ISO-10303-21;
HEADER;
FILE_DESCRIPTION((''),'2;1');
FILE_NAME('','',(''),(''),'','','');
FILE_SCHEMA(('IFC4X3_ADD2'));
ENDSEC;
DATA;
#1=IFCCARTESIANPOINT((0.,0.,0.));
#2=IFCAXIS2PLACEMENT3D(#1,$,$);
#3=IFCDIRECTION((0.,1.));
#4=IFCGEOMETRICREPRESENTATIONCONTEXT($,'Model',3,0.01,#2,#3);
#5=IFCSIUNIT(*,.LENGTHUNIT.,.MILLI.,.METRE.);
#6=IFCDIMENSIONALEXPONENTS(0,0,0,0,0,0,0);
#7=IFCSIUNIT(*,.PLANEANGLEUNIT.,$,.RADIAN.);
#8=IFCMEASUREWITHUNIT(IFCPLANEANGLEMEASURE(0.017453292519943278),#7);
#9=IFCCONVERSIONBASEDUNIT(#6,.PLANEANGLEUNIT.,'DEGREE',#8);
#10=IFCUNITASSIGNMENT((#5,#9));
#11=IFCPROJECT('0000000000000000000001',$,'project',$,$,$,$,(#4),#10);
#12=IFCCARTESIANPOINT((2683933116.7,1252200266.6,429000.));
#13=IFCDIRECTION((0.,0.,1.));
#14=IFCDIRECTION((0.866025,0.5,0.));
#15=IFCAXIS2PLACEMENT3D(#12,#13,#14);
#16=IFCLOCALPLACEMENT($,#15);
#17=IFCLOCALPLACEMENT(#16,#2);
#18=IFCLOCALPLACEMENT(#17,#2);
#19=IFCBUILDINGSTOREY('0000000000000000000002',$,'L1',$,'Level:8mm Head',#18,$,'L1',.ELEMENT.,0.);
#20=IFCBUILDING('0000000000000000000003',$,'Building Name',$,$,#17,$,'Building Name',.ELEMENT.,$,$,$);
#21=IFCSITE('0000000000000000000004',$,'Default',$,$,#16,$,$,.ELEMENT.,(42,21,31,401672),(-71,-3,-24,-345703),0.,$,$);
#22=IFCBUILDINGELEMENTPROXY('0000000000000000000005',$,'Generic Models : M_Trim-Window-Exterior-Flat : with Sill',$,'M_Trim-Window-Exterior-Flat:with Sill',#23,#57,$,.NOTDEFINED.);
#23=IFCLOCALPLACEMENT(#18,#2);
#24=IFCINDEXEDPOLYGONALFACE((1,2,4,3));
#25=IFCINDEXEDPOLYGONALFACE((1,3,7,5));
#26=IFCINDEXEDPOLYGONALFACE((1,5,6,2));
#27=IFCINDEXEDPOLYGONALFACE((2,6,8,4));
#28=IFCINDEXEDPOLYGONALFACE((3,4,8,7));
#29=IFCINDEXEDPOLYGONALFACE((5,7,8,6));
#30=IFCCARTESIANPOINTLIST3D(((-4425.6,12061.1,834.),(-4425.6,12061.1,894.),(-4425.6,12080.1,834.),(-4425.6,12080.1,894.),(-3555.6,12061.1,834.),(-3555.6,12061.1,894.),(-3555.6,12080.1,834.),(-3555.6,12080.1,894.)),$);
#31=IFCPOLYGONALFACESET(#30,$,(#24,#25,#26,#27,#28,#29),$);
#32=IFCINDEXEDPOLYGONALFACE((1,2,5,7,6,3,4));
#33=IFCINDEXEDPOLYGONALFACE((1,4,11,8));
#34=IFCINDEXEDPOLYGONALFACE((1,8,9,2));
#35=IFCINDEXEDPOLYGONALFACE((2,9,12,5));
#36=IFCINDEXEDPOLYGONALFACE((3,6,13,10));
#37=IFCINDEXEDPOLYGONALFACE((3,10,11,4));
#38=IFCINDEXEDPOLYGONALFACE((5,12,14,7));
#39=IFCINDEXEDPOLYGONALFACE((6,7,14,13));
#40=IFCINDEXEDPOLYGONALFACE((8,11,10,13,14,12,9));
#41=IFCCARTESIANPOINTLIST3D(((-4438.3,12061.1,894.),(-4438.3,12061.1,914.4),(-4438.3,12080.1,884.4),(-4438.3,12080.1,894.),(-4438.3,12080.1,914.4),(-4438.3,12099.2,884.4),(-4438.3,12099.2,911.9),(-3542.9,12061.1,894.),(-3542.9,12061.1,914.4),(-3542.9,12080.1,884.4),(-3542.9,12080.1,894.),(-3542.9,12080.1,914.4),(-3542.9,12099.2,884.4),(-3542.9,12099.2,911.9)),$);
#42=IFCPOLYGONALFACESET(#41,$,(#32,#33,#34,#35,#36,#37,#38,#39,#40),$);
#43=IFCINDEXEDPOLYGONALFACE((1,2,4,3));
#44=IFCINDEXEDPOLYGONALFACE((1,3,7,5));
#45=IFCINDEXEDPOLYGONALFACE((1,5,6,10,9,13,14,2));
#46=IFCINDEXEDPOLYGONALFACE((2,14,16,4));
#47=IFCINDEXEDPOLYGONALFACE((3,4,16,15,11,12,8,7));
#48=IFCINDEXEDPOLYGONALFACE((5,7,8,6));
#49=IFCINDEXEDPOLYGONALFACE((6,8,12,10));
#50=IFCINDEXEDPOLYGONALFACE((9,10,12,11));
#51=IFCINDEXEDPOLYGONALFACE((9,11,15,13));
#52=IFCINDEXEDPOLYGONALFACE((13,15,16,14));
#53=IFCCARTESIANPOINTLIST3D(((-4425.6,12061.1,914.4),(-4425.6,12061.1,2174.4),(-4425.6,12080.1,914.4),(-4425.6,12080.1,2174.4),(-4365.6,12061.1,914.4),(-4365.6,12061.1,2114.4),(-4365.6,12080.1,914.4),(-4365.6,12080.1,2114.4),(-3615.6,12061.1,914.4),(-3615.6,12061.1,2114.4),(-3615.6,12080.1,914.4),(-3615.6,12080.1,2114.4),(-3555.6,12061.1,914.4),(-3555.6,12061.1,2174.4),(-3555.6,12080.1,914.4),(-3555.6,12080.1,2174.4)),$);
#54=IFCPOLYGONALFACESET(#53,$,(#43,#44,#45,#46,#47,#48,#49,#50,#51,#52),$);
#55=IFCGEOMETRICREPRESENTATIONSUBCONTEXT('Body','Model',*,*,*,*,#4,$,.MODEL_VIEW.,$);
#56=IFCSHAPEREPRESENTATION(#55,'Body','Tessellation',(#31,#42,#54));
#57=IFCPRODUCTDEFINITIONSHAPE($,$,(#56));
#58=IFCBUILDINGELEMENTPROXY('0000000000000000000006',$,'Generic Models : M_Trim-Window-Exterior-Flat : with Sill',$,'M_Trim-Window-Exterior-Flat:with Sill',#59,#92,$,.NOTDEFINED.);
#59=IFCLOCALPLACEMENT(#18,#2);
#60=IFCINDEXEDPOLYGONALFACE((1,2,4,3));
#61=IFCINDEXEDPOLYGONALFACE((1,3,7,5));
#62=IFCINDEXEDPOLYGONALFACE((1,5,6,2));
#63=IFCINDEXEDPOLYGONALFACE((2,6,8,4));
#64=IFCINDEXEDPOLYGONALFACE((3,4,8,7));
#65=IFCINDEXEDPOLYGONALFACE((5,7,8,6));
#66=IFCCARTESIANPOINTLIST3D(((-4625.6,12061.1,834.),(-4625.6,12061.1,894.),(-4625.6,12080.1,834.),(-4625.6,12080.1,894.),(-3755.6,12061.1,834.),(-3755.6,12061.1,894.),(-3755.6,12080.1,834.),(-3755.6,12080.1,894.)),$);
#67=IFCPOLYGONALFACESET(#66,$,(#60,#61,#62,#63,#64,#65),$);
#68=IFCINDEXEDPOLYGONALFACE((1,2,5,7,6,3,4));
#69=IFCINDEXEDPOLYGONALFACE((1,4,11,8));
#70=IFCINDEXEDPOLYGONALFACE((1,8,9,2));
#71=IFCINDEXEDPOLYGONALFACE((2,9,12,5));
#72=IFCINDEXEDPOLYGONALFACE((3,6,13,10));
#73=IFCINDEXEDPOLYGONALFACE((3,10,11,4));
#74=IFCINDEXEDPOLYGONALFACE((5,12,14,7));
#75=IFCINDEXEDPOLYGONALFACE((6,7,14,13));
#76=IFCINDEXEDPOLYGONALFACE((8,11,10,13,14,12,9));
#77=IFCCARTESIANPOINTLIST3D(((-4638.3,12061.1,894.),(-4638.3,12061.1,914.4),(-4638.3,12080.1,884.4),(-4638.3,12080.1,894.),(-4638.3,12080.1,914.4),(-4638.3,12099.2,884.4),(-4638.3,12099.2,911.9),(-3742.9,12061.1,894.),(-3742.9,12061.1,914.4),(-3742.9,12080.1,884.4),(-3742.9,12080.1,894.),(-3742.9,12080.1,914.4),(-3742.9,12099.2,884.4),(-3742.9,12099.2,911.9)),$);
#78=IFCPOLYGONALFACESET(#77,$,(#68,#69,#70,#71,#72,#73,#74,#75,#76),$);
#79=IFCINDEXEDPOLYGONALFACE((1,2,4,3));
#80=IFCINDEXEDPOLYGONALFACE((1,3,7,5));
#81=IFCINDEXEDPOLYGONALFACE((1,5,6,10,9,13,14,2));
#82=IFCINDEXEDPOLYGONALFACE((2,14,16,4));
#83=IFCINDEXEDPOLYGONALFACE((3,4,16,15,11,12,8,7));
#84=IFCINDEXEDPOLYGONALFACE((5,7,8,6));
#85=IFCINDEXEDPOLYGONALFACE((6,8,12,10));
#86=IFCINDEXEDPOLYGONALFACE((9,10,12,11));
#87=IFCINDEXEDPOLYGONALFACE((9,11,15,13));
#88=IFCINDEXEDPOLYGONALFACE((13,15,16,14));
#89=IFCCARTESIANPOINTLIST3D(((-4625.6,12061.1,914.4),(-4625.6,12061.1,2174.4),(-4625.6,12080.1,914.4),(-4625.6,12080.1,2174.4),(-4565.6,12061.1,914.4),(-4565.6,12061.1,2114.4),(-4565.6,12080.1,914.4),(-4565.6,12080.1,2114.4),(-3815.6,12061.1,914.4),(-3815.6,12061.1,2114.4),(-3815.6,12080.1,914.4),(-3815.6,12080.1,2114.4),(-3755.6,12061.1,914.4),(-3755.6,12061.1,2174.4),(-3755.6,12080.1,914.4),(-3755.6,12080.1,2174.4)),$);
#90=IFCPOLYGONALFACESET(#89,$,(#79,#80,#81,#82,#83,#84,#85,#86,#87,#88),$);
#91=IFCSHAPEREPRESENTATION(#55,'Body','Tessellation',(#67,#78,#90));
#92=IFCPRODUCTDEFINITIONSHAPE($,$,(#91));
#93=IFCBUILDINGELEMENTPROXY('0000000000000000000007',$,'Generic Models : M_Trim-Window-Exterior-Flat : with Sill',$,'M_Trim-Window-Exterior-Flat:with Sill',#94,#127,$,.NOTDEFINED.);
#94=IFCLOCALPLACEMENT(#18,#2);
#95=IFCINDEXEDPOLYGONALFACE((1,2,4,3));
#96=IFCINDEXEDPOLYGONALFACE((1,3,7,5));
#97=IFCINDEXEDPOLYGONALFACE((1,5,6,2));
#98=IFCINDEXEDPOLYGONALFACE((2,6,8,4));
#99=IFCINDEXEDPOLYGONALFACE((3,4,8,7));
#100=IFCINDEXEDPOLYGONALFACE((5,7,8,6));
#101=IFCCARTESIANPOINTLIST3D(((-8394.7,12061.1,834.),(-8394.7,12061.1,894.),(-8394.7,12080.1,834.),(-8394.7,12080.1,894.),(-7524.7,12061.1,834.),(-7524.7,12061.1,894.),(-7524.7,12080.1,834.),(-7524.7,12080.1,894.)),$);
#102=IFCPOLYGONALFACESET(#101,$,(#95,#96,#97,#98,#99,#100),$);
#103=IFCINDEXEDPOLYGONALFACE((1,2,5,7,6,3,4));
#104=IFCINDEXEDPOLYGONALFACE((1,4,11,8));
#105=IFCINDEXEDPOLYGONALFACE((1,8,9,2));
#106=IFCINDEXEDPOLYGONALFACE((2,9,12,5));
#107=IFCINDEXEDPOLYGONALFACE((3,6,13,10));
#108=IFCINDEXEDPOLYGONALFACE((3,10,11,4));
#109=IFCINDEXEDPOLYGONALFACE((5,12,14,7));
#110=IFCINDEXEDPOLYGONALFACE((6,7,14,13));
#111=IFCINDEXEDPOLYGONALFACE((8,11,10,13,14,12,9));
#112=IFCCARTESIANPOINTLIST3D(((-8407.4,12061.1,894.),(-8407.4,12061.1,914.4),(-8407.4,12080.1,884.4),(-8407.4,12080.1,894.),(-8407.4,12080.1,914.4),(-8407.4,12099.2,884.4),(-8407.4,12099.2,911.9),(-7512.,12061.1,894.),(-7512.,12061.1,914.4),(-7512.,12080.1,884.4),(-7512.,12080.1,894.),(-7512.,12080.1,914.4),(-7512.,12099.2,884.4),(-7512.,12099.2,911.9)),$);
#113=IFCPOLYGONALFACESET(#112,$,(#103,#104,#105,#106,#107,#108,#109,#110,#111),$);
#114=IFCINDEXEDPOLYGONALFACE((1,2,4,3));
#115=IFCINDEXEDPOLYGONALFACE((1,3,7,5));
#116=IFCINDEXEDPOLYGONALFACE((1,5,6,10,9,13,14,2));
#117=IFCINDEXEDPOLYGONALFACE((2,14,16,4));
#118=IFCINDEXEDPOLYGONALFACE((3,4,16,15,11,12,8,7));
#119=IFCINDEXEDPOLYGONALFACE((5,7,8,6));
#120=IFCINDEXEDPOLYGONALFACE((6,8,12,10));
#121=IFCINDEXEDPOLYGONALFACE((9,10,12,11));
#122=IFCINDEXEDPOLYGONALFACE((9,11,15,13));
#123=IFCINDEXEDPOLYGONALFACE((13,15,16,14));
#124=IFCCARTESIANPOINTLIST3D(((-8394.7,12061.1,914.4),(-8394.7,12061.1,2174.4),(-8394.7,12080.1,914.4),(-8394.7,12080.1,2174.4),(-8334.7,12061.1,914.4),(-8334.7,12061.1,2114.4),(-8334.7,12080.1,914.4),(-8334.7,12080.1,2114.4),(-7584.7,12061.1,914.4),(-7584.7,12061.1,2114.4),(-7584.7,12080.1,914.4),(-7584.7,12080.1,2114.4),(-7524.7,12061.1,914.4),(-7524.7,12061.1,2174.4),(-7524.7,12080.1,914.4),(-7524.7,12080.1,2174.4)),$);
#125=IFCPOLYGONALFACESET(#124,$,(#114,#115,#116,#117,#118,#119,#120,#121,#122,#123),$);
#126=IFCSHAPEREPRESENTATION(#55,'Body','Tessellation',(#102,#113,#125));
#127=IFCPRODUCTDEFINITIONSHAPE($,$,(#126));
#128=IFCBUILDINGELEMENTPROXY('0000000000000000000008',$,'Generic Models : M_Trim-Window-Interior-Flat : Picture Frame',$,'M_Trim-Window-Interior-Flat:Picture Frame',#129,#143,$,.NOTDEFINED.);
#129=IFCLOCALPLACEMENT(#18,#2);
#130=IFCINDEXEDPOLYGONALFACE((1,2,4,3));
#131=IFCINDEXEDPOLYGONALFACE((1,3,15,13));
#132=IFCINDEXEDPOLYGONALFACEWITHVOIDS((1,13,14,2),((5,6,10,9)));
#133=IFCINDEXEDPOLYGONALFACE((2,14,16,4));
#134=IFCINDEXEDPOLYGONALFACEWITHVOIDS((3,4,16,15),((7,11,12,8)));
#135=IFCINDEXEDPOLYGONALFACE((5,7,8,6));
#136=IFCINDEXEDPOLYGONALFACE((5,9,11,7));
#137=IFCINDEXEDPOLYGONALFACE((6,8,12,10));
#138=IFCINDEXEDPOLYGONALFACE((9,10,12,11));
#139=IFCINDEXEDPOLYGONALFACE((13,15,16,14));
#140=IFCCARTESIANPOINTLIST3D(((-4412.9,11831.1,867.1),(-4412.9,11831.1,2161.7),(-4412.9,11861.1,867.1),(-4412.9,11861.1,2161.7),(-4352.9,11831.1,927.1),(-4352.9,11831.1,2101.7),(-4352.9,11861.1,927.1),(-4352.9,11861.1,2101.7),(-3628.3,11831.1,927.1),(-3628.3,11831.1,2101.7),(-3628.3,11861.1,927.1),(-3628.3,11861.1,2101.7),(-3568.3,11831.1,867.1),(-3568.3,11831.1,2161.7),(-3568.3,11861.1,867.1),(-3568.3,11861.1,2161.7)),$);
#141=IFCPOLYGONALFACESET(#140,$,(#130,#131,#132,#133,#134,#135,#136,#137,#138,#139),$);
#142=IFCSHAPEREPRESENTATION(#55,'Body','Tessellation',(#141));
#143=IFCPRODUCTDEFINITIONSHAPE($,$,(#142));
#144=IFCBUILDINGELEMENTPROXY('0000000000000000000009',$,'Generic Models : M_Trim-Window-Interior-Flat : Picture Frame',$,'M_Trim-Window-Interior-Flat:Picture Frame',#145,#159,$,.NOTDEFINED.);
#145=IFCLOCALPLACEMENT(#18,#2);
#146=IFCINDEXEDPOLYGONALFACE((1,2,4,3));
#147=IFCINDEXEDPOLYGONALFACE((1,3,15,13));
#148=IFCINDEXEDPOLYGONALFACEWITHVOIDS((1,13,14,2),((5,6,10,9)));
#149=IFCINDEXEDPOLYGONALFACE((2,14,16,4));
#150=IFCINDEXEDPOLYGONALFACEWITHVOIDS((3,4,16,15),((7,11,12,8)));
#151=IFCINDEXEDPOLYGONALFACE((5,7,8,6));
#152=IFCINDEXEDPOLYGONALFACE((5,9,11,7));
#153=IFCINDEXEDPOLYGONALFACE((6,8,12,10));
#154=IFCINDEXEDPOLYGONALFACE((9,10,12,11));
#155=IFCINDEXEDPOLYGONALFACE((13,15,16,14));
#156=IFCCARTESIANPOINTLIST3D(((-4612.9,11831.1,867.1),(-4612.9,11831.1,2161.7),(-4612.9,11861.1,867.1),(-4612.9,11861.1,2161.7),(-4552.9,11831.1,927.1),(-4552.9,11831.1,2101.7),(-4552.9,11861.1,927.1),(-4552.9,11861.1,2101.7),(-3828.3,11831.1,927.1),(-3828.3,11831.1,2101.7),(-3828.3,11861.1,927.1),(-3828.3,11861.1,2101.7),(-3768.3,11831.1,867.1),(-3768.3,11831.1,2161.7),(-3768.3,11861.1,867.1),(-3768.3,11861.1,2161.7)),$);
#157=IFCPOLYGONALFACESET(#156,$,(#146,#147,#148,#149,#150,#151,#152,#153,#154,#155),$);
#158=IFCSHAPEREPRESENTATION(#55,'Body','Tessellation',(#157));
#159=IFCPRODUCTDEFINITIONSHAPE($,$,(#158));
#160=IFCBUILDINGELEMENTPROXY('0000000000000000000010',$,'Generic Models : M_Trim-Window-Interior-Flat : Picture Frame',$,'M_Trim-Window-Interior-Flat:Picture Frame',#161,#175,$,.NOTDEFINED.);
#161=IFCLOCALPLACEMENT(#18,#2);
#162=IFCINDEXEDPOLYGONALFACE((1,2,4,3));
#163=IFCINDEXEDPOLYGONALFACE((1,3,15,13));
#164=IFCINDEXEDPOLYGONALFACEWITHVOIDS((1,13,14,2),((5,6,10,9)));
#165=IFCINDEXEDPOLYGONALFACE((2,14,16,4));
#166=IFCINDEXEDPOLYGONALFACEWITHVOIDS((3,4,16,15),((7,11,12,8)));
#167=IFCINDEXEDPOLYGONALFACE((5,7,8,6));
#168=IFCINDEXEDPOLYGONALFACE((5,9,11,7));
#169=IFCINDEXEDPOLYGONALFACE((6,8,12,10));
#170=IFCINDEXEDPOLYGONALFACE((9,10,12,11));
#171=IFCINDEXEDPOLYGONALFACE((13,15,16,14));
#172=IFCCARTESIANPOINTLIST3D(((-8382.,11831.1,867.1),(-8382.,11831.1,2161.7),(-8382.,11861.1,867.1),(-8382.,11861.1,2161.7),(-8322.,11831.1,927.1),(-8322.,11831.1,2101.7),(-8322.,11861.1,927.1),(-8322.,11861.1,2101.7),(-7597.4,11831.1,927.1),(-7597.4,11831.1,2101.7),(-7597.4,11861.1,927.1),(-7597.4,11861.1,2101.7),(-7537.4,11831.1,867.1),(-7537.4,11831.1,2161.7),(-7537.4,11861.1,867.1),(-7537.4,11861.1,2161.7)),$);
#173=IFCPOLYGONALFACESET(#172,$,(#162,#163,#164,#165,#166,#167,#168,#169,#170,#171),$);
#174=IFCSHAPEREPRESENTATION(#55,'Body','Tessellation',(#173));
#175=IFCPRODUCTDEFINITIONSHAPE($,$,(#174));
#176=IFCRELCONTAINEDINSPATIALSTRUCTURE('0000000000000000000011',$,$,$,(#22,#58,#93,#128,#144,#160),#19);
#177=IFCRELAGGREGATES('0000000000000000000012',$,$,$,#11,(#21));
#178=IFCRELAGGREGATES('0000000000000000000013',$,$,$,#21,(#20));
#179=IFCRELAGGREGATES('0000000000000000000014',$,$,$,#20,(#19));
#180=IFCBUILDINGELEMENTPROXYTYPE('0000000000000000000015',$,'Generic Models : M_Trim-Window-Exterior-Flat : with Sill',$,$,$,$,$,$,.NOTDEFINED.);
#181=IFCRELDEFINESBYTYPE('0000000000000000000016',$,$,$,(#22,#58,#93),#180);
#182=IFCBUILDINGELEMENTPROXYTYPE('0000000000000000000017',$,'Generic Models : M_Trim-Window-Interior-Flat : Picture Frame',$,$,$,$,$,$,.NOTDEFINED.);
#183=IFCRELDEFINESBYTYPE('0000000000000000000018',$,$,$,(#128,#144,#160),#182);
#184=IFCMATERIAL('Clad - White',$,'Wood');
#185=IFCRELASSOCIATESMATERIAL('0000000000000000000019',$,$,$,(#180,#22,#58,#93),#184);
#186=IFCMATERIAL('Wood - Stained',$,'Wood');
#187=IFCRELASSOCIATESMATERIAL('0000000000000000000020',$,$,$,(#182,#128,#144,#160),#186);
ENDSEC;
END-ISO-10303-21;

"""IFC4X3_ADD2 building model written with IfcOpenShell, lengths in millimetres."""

from ifc_helpers import new_model, entity, si_unit, converted_unit, direction, frame, frame_2d, origin, place, context, subcontext, project, spatial, polyline, rectangle, outline, extrude, source, transform, mapped, material, type_object, type_shapes, element, save


model = new_model("IFC4X3_ADD2")

# Units and contexts
model_context = context("Model", 3, precision=0.01, world=origin(), true_north=direction((0.0, 1.0)))
body_context = subcontext(model_context, "Body", "Model", "MODEL_VIEW")
ifc_project = project(units=[si_unit("LENGTHUNIT", "METRE", prefix="MILLI"), converted_unit("PLANEANGLEUNIT", "DEGREE", entity("IfcPlaneAngleMeasure", 0.017453292519943278), si_unit("PLANEANGLEUNIT", "RADIAN"), dimensions=[0, 0, 0, 0, 0, 0, 0])], contexts=[model_context])

# Site, building, storey
site_placement = place(None, frame((2683933116.7, 1252200266.6, 429000.0), z_axis=(0.0, 0.0, 1.0), x_axis=(0.866025, 0.5, 0.0)))
site = spatial("IfcSite", under=ifc_project, at=site_placement, Name="Default", CompositionType="ELEMENT", RefLatitude=(42, 21, 31, 401672), RefLongitude=(-71, -3, -24, -345703), RefElevation=0.0)
building_placement = place(site_placement, origin())
building = spatial("IfcBuilding", under=site, at=building_placement, Name="Building Name", LongName="Building Name", CompositionType="ELEMENT")
storey_placement = place(building_placement, origin())
storey = spatial("IfcBuildingStorey", under=building, at=storey_placement, Name="L1", ObjectType="Level:8mm Head", LongName="L1", CompositionType="ELEMENT", Elevation=0.0)

# Shared definitions
ifc_material_1 = material(Name="Wood - Stained", Category="Wood")

# Building element proxies
ifc_material_2 = material(Name="Clad - White", Category="Wood")
building_element_proxy_type_1 = type_object("IfcBuildingElementProxyType", Name="Generic Models : M_Trim-Window-Exterior-Flat : with Sill", PredefinedType="NOTDEFINED", material=ifc_material_2)
shared_shape_1 = source(origin(), body_context, "Body", "SweptSolid", [
    extrude(rectangle(XDim=870.0, YDim=60.0, at=frame_2d((0.0, 0.0), x_axis=(1.0, 0.0))), frame((0.0, -1250.4, 0.0), z_axis=(0.0, 0.0, 1.0), x_axis=(-1.0, 0.0, 0.0)), (0.0, 0.0, 1.0), 19.0),
    extrude(outline(polyline([(-19.0, -15.2), (0.0, -15.2), (0.0, -5.7), (19.0, -5.7), (19.0, 14.8), (0.0, 14.8), (-19.0, 12.3), (-19.0, -15.2)])), frame((-447.7, -1214.8, 19.0), z_axis=(1.0, 0.0, 0.0), x_axis=(0.0, 0.0, -1.0)), (0.0, 0.0, 1.0), 895.4),
    extrude(outline(polyline([(-645.0, -435.0), (615.0, -435.0), (615.0, -375.0), (-585.0, -375.0), (-585.0, 375.0), (615.0, 375.0), (615.0, 435.0), (-645.0, 435.0), (-645.0, -435.0)])), frame((0.0, -585.0, 0.0), z_axis=(0.0, 0.0, 1.0), x_axis=(0.0, -1.0, 0.0)), (0.0, 0.0, 1.0), 19.0),
])
type_shapes(building_element_proxy_type_1, [shared_shape_1])
for number, where, z_axis, x_axis, name in (
    (1, (-3990.6, 12061.1, 2114.4), (0.0, 1.0, 0.0), (-1.0, 0.0, 0.0), "Generic Models : M_Trim-Window-Exterior-Flat : with Sill"),
    (2, (-4190.6, 12061.1, 2114.4), (0.0, 1.0, 0.0), (-1.0, 0.0, 0.0), "Generic Models : M_Trim-Window-Exterior-Flat : with Sill"),
    (3, (-7959.7, 12061.1, 2114.4), (0.0, 1.0, 0.0), (-1.0, 0.0, 0.0), "Generic Models : M_Trim-Window-Exterior-Flat : with Sill"),
):
    element("IfcBuildingElementProxy", number, at=place(storey_placement, frame(where, z_axis=z_axis, x_axis=x_axis)), inside=storey, type_object=building_element_proxy_type_1, material=ifc_material_2, Name=name, ObjectType="M_Trim-Window-Exterior-Flat:with Sill", PredefinedType="NOTDEFINED", context=body_context, shape_type="MappedRepresentation", body=[
        mapped(shared_shape_1, transform((0.0, 0.0, 0.0), scale=1.0)),
    ])
building_element_proxy_type_2 = type_object("IfcBuildingElementProxyType", Name="Generic Models : M_Trim-Window-Interior-Flat : Picture Frame", PredefinedType="NOTDEFINED", material=ifc_material_1)
shared_shape_2 = source(origin(), body_context, "Body", "SweptSolid", [
    extrude(outline(polyline([(-422.3, -647.3), (422.3, -647.3), (422.3, 647.3), (-422.3, 647.3), (-422.3, -647.3)]), holes=[polyline([(-362.3, -587.3), (-362.3, 587.3), (362.3, 587.3), (362.3, -587.3), (-362.3, -587.3)])]), frame((0.0, -600.0, 0.0), z_axis=(0.0, 0.0, 1.0), x_axis=(-1.0, 0.0, 0.0)), (0.0, 0.0, 1.0), 30.0),
])
type_shapes(building_element_proxy_type_2, [shared_shape_2])
for number, where, z_axis, x_axis, name in (
    (4, (-3990.6, 11861.1, 2114.4), (0.0, -1.0, 0.0), (1.0, 0.0, 0.0), "Generic Models : M_Trim-Window-Interior-Flat : Picture Frame"),
    (5, (-4190.6, 11861.1, 2114.4), (0.0, -1.0, 0.0), (1.0, 0.0, 0.0), "Generic Models : M_Trim-Window-Interior-Flat : Picture Frame"),
    (6, (-7959.7, 11861.1, 2114.4), (0.0, -1.0, 0.0), (1.0, 0.0, 0.0), "Generic Models : M_Trim-Window-Interior-Flat : Picture Frame"),
):
    element("IfcBuildingElementProxy", number, at=place(storey_placement, frame(where, z_axis=z_axis, x_axis=x_axis)), inside=storey, type_object=building_element_proxy_type_2, material=ifc_material_1, Name=name, ObjectType="M_Trim-Window-Interior-Flat:Picture Frame", PredefinedType="NOTDEFINED", context=body_context, shape_type="MappedRepresentation", body=[
        mapped(shared_shape_2, transform((0.0, 0.0, 0.0), scale=1.0)),
    ])

save(model, "model.ifc")
